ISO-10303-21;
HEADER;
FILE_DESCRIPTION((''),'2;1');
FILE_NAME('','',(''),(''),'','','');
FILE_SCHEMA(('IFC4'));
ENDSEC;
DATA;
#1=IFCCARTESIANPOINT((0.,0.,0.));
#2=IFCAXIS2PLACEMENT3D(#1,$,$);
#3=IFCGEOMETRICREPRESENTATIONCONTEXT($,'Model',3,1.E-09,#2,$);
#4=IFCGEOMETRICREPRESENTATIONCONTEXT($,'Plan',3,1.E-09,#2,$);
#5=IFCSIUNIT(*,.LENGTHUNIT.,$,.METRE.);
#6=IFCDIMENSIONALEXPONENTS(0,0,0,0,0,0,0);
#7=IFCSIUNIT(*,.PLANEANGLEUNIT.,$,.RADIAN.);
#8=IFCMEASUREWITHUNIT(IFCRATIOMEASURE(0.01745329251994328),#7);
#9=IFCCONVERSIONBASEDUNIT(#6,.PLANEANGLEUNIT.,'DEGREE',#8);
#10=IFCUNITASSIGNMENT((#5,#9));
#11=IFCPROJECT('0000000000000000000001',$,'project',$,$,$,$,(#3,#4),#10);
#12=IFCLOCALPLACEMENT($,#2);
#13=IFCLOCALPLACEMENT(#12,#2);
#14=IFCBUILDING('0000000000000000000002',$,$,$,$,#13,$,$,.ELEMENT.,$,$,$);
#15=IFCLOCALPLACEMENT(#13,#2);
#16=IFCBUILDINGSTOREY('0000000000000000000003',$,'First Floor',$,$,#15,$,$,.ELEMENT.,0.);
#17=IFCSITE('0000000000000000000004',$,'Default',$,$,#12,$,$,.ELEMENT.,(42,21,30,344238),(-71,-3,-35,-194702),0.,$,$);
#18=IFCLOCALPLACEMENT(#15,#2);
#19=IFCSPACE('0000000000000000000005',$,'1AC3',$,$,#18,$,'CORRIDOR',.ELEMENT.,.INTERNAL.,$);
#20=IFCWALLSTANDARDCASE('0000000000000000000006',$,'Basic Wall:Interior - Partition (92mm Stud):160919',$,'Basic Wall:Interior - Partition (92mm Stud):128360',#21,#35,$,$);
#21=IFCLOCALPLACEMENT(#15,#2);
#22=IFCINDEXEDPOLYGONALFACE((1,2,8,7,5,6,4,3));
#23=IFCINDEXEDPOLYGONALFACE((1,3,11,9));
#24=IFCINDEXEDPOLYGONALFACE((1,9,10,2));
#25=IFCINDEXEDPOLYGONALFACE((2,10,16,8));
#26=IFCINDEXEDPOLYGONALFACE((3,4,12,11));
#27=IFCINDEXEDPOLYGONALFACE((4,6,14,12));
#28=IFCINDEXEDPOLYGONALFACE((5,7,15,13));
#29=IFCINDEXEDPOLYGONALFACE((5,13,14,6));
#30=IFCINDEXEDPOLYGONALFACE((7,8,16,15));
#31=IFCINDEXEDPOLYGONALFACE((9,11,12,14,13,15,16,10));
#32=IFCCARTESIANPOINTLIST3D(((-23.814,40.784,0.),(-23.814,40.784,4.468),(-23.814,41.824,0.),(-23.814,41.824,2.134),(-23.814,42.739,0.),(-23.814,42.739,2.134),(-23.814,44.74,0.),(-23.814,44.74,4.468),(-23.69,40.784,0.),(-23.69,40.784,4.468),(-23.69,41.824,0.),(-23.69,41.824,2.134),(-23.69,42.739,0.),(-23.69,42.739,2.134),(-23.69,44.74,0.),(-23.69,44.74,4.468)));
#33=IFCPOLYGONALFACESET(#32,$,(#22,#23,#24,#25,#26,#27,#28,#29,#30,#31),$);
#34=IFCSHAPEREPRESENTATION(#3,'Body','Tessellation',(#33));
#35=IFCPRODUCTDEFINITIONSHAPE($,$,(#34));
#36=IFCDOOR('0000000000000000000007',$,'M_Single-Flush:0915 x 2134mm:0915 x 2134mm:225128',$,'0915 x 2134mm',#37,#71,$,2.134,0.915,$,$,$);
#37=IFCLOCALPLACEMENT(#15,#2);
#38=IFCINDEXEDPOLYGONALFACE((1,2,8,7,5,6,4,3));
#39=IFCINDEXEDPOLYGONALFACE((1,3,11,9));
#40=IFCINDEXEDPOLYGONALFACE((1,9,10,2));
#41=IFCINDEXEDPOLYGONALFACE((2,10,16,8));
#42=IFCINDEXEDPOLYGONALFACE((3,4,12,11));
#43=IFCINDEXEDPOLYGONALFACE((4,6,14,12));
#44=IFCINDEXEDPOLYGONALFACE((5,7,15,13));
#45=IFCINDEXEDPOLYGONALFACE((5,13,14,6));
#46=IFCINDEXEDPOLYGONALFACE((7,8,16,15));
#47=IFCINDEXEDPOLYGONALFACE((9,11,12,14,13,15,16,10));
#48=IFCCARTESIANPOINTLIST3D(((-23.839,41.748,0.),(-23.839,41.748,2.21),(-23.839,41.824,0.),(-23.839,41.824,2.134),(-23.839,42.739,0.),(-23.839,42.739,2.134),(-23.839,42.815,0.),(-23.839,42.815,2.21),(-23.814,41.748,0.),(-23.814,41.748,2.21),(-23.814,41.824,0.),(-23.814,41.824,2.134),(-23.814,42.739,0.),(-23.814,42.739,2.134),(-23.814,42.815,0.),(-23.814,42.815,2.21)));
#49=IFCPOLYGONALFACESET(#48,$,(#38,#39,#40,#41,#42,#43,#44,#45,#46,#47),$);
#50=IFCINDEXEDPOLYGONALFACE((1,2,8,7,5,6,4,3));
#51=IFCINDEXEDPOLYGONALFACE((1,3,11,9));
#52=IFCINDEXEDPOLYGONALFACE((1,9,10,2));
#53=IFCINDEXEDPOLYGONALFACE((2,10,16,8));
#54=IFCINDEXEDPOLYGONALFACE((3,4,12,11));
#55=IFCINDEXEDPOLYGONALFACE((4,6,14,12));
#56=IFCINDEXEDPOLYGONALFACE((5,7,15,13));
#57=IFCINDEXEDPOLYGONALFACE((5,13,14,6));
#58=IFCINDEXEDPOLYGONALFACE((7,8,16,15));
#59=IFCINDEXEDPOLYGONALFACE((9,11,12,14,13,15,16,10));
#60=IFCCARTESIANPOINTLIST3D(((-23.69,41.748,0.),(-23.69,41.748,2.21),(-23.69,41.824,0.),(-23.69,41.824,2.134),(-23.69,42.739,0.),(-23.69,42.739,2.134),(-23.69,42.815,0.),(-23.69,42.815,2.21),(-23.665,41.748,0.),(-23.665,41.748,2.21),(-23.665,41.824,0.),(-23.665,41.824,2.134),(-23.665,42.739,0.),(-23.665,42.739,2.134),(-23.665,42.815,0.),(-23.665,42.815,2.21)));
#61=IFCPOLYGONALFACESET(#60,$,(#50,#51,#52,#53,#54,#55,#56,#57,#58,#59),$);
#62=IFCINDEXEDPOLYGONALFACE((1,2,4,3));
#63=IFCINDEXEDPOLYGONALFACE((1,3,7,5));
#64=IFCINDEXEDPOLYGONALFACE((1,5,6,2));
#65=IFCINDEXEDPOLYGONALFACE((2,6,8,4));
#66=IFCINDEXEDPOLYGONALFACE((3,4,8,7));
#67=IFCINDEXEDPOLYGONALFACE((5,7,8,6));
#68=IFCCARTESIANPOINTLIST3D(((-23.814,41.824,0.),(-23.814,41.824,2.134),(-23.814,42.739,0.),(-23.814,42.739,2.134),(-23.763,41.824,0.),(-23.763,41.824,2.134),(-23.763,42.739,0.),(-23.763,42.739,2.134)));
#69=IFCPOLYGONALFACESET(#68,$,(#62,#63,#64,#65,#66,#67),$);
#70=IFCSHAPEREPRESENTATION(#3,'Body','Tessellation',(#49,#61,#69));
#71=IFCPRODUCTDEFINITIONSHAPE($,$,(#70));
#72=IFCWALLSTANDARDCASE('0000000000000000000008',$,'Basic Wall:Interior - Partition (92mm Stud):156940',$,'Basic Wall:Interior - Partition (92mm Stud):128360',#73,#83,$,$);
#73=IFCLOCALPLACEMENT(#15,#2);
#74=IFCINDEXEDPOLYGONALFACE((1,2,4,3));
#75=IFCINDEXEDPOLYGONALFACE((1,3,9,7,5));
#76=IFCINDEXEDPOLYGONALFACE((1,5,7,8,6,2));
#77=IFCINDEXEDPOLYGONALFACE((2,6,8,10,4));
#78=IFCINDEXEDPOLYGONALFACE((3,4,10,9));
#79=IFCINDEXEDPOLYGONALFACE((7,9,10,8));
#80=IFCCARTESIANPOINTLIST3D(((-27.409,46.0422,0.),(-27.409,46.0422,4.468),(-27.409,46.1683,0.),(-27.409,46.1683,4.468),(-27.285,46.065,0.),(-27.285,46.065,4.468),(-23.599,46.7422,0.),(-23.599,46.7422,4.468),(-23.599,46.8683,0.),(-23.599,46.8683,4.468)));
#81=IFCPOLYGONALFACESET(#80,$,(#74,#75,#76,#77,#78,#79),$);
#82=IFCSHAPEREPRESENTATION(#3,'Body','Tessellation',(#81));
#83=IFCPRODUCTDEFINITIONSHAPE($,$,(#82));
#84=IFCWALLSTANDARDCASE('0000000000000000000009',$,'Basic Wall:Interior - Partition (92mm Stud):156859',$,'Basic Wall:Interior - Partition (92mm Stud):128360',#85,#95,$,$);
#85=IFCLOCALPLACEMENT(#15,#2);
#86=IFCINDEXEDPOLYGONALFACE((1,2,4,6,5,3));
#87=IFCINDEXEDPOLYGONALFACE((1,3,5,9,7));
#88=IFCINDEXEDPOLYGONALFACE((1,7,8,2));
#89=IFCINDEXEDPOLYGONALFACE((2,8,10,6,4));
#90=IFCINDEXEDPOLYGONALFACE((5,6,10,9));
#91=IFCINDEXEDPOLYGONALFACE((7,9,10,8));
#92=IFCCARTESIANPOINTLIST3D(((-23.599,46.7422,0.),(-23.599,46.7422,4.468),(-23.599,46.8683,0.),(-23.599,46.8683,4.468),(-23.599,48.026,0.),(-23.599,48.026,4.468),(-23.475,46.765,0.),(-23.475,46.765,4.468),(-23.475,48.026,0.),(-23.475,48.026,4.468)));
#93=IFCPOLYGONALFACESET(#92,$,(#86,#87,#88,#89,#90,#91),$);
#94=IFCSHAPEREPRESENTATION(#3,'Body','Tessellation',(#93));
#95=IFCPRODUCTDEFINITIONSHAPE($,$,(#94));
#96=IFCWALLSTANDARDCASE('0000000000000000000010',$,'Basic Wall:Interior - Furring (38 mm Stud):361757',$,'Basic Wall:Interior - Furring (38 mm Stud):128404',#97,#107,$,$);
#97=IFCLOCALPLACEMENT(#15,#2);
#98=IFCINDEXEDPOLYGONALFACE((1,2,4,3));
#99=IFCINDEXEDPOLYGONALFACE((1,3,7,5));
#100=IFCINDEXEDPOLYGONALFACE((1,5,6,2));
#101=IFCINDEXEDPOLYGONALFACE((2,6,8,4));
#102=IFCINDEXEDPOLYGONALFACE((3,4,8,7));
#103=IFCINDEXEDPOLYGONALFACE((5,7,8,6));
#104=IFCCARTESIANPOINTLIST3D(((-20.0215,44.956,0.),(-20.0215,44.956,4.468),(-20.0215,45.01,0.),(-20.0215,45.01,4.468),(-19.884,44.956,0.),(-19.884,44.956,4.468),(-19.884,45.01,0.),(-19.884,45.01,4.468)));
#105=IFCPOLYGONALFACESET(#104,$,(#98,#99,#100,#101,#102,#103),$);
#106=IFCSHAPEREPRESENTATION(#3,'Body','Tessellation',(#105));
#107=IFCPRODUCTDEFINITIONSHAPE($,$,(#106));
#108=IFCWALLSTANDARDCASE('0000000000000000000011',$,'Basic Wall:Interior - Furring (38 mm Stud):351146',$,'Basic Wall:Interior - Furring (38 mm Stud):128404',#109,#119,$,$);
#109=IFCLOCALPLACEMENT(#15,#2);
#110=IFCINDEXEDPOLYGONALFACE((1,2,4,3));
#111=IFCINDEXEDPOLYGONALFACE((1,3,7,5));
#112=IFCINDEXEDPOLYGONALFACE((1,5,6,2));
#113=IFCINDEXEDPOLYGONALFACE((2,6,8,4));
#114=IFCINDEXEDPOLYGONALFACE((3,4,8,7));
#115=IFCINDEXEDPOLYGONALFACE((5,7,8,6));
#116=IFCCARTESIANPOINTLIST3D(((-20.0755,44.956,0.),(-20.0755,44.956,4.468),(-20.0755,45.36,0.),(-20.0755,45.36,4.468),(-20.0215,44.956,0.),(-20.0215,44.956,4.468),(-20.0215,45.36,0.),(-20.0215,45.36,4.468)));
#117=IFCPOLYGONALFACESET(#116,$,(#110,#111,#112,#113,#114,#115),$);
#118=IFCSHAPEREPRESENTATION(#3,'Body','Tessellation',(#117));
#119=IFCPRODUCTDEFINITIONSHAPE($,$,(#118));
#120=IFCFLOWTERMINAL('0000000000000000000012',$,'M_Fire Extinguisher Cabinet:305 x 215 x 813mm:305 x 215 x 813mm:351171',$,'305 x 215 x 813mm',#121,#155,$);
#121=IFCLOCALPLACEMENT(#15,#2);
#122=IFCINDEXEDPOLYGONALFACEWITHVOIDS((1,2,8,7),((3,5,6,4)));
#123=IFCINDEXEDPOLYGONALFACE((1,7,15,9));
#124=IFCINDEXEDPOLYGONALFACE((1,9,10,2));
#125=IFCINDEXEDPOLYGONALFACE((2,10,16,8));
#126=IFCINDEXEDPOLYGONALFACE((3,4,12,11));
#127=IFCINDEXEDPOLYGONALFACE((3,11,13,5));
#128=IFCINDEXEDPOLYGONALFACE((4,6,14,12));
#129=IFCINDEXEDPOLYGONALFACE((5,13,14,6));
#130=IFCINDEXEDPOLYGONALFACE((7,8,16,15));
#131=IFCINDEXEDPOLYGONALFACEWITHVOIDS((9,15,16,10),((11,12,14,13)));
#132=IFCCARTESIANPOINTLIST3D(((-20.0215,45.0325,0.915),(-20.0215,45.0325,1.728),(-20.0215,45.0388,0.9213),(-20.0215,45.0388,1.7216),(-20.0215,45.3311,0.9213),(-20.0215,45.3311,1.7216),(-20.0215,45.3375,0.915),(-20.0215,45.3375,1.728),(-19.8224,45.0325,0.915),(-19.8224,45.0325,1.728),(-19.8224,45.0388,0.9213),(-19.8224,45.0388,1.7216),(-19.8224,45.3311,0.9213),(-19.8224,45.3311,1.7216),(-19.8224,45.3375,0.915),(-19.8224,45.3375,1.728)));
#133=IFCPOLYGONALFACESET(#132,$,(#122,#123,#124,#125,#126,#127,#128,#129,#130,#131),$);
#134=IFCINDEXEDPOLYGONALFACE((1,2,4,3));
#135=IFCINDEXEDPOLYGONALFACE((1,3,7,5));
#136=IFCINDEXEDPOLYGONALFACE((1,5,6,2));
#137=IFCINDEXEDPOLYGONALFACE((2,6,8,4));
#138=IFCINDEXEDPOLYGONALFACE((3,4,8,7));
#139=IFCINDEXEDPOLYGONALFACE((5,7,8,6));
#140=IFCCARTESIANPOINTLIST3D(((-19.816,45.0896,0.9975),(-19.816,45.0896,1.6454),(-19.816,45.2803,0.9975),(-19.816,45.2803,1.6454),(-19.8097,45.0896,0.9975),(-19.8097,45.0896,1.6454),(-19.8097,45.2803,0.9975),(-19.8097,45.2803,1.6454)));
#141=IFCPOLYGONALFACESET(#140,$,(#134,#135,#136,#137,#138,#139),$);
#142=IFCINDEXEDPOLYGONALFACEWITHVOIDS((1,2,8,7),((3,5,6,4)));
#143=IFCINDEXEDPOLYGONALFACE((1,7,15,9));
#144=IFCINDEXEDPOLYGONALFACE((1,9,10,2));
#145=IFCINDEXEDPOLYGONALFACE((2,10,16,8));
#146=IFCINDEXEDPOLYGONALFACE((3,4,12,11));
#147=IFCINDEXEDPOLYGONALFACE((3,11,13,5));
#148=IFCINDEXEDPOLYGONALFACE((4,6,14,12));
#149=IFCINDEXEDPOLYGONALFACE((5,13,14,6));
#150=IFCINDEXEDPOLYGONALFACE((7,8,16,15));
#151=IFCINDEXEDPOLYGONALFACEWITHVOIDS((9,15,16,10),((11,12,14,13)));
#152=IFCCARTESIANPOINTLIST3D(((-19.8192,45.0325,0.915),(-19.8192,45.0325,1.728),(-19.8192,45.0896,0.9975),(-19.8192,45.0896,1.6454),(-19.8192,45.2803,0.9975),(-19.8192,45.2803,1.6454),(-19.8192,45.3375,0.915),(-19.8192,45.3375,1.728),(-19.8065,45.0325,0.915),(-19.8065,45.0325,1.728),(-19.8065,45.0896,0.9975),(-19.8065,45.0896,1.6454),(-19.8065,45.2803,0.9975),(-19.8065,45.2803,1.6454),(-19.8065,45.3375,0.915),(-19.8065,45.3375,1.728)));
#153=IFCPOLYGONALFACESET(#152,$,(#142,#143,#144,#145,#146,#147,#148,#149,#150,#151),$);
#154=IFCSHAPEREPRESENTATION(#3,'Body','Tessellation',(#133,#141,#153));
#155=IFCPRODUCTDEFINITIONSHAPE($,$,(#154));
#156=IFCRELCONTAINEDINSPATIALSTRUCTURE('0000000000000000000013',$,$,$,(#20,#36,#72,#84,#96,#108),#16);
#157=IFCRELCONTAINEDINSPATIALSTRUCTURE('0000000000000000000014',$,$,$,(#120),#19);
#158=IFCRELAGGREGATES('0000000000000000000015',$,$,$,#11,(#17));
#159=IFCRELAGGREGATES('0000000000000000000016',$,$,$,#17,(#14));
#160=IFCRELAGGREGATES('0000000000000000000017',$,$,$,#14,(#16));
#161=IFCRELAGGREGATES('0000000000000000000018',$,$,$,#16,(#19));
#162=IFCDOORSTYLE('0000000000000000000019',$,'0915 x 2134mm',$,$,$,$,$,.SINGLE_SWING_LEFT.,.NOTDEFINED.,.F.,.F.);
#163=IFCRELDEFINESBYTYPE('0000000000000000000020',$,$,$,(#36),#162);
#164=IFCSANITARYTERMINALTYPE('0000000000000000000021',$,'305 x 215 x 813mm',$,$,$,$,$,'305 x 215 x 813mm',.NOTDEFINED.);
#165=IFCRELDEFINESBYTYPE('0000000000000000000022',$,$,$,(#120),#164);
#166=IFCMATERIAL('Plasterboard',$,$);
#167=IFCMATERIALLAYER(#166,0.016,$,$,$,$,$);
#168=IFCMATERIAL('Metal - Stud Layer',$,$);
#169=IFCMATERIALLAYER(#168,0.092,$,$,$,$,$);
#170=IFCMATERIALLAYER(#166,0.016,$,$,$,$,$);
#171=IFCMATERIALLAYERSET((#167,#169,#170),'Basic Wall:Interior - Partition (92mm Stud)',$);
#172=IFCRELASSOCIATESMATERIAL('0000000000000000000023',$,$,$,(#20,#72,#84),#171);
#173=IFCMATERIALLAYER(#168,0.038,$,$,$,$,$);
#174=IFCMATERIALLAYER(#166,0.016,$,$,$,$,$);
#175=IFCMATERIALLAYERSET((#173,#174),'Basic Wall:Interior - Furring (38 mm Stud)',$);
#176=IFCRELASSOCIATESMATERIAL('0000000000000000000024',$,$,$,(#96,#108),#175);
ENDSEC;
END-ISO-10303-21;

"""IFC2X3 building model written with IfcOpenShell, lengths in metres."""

from ifc_helpers import new_model, entity, si_unit, converted_unit, frame, frame_2d, origin, origin_2d_with_axis, place, context, project, spatial, polyline, rectangle, outline, extrude, source, transform, mapped, material, layer, layer_set, layer_usage, type_object, type_shapes, element, fill, save


model = new_model("IFC2X3")

# Units and contexts
model_context = context("Model", 3, precision=1e-09, world=origin())
plan_context = context("Plan", 3, precision=1e-09, world=origin())
ifc_project = project(units=[si_unit("LENGTHUNIT", "METRE"), converted_unit("PLANEANGLEUNIT", "DEGREE", entity("IfcRatioMeasure", 0.01745329251994328), si_unit("PLANEANGLEUNIT", "RADIAN"), dimensions=[0, 0, 0, 0, 0, 0, 0])], contexts=[model_context, plan_context])

# Site, building, storey
site_placement = place(None, origin())
site = spatial("IfcSite", under=ifc_project, at=site_placement, Name="Default", CompositionType="ELEMENT", RefLatitude=(42, 21, 30, 344238), RefLongitude=(-71, -3, -35, -194702), RefElevation=0.0)
building_placement = place(site_placement, origin())
building = spatial("IfcBuilding", under=site, at=building_placement, CompositionType="ELEMENT")
storey_placement = place(building_placement, origin())
storey = spatial("IfcBuildingStorey", under=building, at=storey_placement, Name="First Floor", CompositionType="ELEMENT", Elevation=0.0)

# Shared definitions
ifc_material_1 = material(Name="Metal - Stud Layer")
ifc_layer_1 = layer(ifc_material_1, 0.038)
ifc_material_2 = material(Name="Plasterboard")
ifc_layer_2 = layer(ifc_material_2, 0.016)
ifc_layer_set_1 = layer_set([ifc_layer_1, ifc_layer_2], Name="Basic Wall:Interior - Furring (38 mm Stud)")
ifc_layer_usage_1 = layer_usage(ifc_layer_set_1, "AXIS2", "NEGATIVE", 0.027)
ifc_layer_usage_2 = layer_usage(ifc_layer_set_1, "AXIS2", "POSITIVE", -0.027)

# Shared definitions
ifc_layer_3 = layer(ifc_material_2, 0.016)
ifc_layer_4 = layer(ifc_material_1, 0.092)
ifc_layer_5 = layer(ifc_material_2, 0.016)
ifc_layer_set_2 = layer_set([ifc_layer_3, ifc_layer_4, ifc_layer_5], Name="Basic Wall:Interior - Partition (92mm Stud)")
ifc_layer_usage_3 = layer_usage(ifc_layer_set_2, "AXIS2", "NEGATIVE", 0.062)

# Wall, opening, door
wall_1_placement = place(storey_placement, frame((-23.752, 44.74, 0.0), z_axis=(0.0, 0.0, 1.0), x_axis=(0.0, -1.0, 0.0)))
wall_1 = element("IfcWallStandardCase", 1, at=wall_1_placement, inside=storey, material=ifc_layer_usage_3, Name="Basic Wall:Interior - Partition (92mm Stud):160919", ObjectType="Basic Wall:Interior - Partition (92mm Stud):128360", context=model_context, shape_type="SweptSolid", body=[
    extrude(rectangle(XDim=3.956, YDim=0.124, at=frame_2d((1.978, 0.0), x_axis=(-1.0, 0.0))), origin(), (0.0, 0.0, 1.0), 4.468),
])
opening_1_placement = place(wall_1_placement, frame((2.916, 0.062, 0.0)))
opening_1 = element("IfcOpeningElement", 2, at=opening_1_placement, cuts=wall_1, ObjectType="Opening", context=model_context, shape_type="SweptSolid", body=[
    extrude(rectangle(XDim=0.915, YDim=2.134, at=frame_2d((1.067, 0.4575), x_axis=(0.0, -1.0))), frame((0.0, 0.0, 0.0), z_axis=(0.0, -1.0, 0.0), x_axis=(0.0, 0.0, 1.0)), (0.0, 0.0, 1.0), 0.124),
])
door_style_1 = type_object("IfcDoorStyle", Name="0915 x 2134mm", ConstructionType="NOTDEFINED", OperationType="SINGLE_SWING_LEFT", ParameterTakesPrecedence=False, Sizeable=False)
shared_shape_1 = source(origin(), model_context, "Body", "SweptSolid", [
    extrude(outline(polyline([(-0.5335, -1.124), (0.5335, -1.124), (0.5335, 1.086), (0.4575, 1.086), (0.4575, -1.048), (-0.4575, -1.048), (-0.4575, 1.086), (-0.5335, 1.086), (-0.5335, -1.124)])), frame((0.4575, 0.149, 1.086), z_axis=(0.0, -1.0, 0.0), x_axis=(-1.0, 0.0, 0.0)), (0.0, 0.0, 1.0), 0.025),
    extrude(outline(polyline([(-1.124, -0.5335), (1.086, -0.5335), (1.086, -0.4575), (-1.048, -0.4575), (-1.048, 0.4575), (1.086, 0.4575), (1.086, 0.5335), (-1.124, 0.5335), (-1.124, -0.5335)])), frame((0.4575, 0.0, 1.086), z_axis=(0.0, -1.0, 0.0), x_axis=(0.0, 0.0, -1.0)), (0.0, 0.0, 1.0), 0.025),
    extrude(rectangle(XDim=0.915, YDim=0.051, at=origin_2d_with_axis()), frame((0.4575, 0.0985, 0.0)), (0.0, 0.0, 1.0), 2.134),
])
type_shapes(door_style_1, [shared_shape_1])
door_1_placement = place(opening_1_placement, frame((0.0, 0.0, 0.0), z_axis=(0.0, 0.0, 1.0), x_axis=(-1.0, 0.0, 0.0)))
door_1 = element("IfcDoor", 3, at=door_1_placement, inside=storey, type_object=door_style_1, Name="M_Single-Flush:0915 x 2134mm:0915 x 2134mm:225128", ObjectType="0915 x 2134mm", OverallHeight=2.134, OverallWidth=0.915, context=model_context, shape_type="MappedRepresentation", body=[
    mapped(shared_shape_1, transform((0.0, 0.0, 0.0), scale=1.0)),
])
fill(opening_1, door_1)

# Walls
wall_2_placement = place(storey_placement, frame((-23.5878, 46.8073, 0.0), z_axis=(0.0, 0.0, 1.0), x_axis=(-0.983538, -0.180702, 0.0)))
element("IfcWallStandardCase", 4, at=wall_2_placement, inside=storey, material=ifc_layer_usage_3, Name="Basic Wall:Interior - Partition (92mm Stud):156940", ObjectType="Basic Wall:Interior - Partition (92mm Stud):128360", context=model_context, shape_type="SweptSolid", body=[
    extrude(outline(polyline([(3.8738, -0.062), (3.8966, 0.062), (3.7705, 0.062), (0.0228, 0.062), (0.0, -0.062), (3.8738, -0.062)])), origin(), (0.0, 0.0, 1.0), 4.468),
])
wall_3_placement = place(storey_placement, frame((-23.537, 48.026, 0.0), z_axis=(0.0, 0.0, 1.0), x_axis=(0.0, -1.0, 0.0)))
element("IfcWallStandardCase", 5, at=wall_3_placement, inside=storey, material=ifc_layer_usage_3, Name="Basic Wall:Interior - Partition (92mm Stud):156859", ObjectType="Basic Wall:Interior - Partition (92mm Stud):128360", context=model_context, shape_type="SweptSolid", body=[
    extrude(outline(polyline([(1.2838, -0.062), (1.261, 0.062), (0.0, 0.062), (0.0, -0.062), (1.1577, -0.062), (1.2838, -0.062)])), origin(), (0.0, 0.0, 1.0), 4.468),
])
wall_4_placement = place(storey_placement, frame((-19.884, 44.983, 0.0), z_axis=(0.0, 0.0, 1.0), x_axis=(-1.0, 0.0, 0.0)))
element("IfcWallStandardCase", 6, at=wall_4_placement, inside=storey, material=ifc_layer_usage_1, Name="Basic Wall:Interior - Furring (38 mm Stud):361757", ObjectType="Basic Wall:Interior - Furring (38 mm Stud):128404", context=model_context, shape_type="SweptSolid", body=[
    extrude(rectangle(XDim=0.1375, YDim=0.054, at=frame_2d((0.0688, 0.0), x_axis=(-1.0, 0.0))), origin(), (0.0, 0.0, 1.0), 4.468),
])
wall_5_placement = place(storey_placement, frame((-20.0485, 45.36, 0.0), z_axis=(0.0, 0.0, 1.0), x_axis=(0.0, -1.0, 0.0)))
element("IfcWallStandardCase", 7, at=wall_5_placement, inside=storey, material=ifc_layer_usage_2, Name="Basic Wall:Interior - Furring (38 mm Stud):351146", ObjectType="Basic Wall:Interior - Furring (38 mm Stud):128404", context=model_context, shape_type="SweptSolid", body=[
    extrude(rectangle(XDim=0.404, YDim=0.054, at=frame_2d((0.202, 0.0), x_axis=(-1.0, 0.0))), origin(), (0.0, 0.0, 1.0), 4.468),
])

# Shared definitions
space_1_placement = place(storey_placement, origin())
space_1 = spatial("IfcSpace", under=storey, at=space_1_placement, Name="1AC3", LongName="CORRIDOR", CompositionType="ELEMENT", InteriorOrExteriorSpace="INTERNAL")

# Flow terminal
sanitary_terminal_type = type_object("IfcSanitaryTerminalType", Name="305 x 215 x 813mm", ElementType="305 x 215 x 813mm", PredefinedType="NOTDEFINED")
shared_shape_2 = source(origin(), model_context, "Body", "SweptSolid", [
    extrude(outline(polyline([(-0.1525, -0.4065), (0.1525, -0.4065), (0.1525, 0.4065), (-0.1525, 0.4065), (-0.1525, -0.4065)]), holes=[polyline([(-0.1462, -0.4001), (-0.1462, 0.4002), (0.1462, 0.4002), (0.1462, -0.4001), (-0.1462, -0.4001)])]), frame((-0.1096, 0.027, 1.3215), z_axis=(0.0, 1.0, 0.0), x_axis=(1.0, 0.0, 0.0)), (0.0, 0.0, 1.0), 0.1991),
    extrude(rectangle(XDim=0.0064, YDim=0.1907, at=origin_2d_with_axis()), frame((-0.1096, 0.2356, 0.9975), z_axis=(0.0, 0.0, 1.0), x_axis=(0.0, -1.0, 0.0)), (0.0, 0.0, 1.0), 0.6479),
    extrude(outline(polyline([(-0.1525, -0.4065), (0.1525, -0.4065), (0.1525, 0.4065), (-0.1525, 0.4065), (-0.1525, -0.4065)]), holes=[polyline([(-0.0953, -0.3239), (-0.0953, 0.324), (0.0954, 0.324), (0.0954, -0.3239), (-0.0953, -0.3239)])]), frame((-0.1096, 0.2293, 1.3215), z_axis=(0.0, 1.0, 0.0), x_axis=(1.0, 0.0, 0.0)), (0.0, 0.0, 1.0), 0.0127),
])
type_shapes(sanitary_terminal_type, [shared_shape_2])
flow_terminal_placement = place(space_1_placement, frame((-20.0485, 45.0754, 0.0), z_axis=(0.0, 0.0, 1.0), x_axis=(0.0, -1.0, 0.0)))
element("IfcFlowTerminal", 8, at=flow_terminal_placement, inside=space_1, type_object=sanitary_terminal_type, Name="M_Fire Extinguisher Cabinet:305 x 215 x 813mm:305 x 215 x 813mm:351171", ObjectType="305 x 215 x 813mm", context=model_context, shape_type="MappedRepresentation", body=[
    mapped(shared_shape_2, transform((0.0, 0.0, 0.0), scale=1.0)),
])

save(model, "model.ifc")
